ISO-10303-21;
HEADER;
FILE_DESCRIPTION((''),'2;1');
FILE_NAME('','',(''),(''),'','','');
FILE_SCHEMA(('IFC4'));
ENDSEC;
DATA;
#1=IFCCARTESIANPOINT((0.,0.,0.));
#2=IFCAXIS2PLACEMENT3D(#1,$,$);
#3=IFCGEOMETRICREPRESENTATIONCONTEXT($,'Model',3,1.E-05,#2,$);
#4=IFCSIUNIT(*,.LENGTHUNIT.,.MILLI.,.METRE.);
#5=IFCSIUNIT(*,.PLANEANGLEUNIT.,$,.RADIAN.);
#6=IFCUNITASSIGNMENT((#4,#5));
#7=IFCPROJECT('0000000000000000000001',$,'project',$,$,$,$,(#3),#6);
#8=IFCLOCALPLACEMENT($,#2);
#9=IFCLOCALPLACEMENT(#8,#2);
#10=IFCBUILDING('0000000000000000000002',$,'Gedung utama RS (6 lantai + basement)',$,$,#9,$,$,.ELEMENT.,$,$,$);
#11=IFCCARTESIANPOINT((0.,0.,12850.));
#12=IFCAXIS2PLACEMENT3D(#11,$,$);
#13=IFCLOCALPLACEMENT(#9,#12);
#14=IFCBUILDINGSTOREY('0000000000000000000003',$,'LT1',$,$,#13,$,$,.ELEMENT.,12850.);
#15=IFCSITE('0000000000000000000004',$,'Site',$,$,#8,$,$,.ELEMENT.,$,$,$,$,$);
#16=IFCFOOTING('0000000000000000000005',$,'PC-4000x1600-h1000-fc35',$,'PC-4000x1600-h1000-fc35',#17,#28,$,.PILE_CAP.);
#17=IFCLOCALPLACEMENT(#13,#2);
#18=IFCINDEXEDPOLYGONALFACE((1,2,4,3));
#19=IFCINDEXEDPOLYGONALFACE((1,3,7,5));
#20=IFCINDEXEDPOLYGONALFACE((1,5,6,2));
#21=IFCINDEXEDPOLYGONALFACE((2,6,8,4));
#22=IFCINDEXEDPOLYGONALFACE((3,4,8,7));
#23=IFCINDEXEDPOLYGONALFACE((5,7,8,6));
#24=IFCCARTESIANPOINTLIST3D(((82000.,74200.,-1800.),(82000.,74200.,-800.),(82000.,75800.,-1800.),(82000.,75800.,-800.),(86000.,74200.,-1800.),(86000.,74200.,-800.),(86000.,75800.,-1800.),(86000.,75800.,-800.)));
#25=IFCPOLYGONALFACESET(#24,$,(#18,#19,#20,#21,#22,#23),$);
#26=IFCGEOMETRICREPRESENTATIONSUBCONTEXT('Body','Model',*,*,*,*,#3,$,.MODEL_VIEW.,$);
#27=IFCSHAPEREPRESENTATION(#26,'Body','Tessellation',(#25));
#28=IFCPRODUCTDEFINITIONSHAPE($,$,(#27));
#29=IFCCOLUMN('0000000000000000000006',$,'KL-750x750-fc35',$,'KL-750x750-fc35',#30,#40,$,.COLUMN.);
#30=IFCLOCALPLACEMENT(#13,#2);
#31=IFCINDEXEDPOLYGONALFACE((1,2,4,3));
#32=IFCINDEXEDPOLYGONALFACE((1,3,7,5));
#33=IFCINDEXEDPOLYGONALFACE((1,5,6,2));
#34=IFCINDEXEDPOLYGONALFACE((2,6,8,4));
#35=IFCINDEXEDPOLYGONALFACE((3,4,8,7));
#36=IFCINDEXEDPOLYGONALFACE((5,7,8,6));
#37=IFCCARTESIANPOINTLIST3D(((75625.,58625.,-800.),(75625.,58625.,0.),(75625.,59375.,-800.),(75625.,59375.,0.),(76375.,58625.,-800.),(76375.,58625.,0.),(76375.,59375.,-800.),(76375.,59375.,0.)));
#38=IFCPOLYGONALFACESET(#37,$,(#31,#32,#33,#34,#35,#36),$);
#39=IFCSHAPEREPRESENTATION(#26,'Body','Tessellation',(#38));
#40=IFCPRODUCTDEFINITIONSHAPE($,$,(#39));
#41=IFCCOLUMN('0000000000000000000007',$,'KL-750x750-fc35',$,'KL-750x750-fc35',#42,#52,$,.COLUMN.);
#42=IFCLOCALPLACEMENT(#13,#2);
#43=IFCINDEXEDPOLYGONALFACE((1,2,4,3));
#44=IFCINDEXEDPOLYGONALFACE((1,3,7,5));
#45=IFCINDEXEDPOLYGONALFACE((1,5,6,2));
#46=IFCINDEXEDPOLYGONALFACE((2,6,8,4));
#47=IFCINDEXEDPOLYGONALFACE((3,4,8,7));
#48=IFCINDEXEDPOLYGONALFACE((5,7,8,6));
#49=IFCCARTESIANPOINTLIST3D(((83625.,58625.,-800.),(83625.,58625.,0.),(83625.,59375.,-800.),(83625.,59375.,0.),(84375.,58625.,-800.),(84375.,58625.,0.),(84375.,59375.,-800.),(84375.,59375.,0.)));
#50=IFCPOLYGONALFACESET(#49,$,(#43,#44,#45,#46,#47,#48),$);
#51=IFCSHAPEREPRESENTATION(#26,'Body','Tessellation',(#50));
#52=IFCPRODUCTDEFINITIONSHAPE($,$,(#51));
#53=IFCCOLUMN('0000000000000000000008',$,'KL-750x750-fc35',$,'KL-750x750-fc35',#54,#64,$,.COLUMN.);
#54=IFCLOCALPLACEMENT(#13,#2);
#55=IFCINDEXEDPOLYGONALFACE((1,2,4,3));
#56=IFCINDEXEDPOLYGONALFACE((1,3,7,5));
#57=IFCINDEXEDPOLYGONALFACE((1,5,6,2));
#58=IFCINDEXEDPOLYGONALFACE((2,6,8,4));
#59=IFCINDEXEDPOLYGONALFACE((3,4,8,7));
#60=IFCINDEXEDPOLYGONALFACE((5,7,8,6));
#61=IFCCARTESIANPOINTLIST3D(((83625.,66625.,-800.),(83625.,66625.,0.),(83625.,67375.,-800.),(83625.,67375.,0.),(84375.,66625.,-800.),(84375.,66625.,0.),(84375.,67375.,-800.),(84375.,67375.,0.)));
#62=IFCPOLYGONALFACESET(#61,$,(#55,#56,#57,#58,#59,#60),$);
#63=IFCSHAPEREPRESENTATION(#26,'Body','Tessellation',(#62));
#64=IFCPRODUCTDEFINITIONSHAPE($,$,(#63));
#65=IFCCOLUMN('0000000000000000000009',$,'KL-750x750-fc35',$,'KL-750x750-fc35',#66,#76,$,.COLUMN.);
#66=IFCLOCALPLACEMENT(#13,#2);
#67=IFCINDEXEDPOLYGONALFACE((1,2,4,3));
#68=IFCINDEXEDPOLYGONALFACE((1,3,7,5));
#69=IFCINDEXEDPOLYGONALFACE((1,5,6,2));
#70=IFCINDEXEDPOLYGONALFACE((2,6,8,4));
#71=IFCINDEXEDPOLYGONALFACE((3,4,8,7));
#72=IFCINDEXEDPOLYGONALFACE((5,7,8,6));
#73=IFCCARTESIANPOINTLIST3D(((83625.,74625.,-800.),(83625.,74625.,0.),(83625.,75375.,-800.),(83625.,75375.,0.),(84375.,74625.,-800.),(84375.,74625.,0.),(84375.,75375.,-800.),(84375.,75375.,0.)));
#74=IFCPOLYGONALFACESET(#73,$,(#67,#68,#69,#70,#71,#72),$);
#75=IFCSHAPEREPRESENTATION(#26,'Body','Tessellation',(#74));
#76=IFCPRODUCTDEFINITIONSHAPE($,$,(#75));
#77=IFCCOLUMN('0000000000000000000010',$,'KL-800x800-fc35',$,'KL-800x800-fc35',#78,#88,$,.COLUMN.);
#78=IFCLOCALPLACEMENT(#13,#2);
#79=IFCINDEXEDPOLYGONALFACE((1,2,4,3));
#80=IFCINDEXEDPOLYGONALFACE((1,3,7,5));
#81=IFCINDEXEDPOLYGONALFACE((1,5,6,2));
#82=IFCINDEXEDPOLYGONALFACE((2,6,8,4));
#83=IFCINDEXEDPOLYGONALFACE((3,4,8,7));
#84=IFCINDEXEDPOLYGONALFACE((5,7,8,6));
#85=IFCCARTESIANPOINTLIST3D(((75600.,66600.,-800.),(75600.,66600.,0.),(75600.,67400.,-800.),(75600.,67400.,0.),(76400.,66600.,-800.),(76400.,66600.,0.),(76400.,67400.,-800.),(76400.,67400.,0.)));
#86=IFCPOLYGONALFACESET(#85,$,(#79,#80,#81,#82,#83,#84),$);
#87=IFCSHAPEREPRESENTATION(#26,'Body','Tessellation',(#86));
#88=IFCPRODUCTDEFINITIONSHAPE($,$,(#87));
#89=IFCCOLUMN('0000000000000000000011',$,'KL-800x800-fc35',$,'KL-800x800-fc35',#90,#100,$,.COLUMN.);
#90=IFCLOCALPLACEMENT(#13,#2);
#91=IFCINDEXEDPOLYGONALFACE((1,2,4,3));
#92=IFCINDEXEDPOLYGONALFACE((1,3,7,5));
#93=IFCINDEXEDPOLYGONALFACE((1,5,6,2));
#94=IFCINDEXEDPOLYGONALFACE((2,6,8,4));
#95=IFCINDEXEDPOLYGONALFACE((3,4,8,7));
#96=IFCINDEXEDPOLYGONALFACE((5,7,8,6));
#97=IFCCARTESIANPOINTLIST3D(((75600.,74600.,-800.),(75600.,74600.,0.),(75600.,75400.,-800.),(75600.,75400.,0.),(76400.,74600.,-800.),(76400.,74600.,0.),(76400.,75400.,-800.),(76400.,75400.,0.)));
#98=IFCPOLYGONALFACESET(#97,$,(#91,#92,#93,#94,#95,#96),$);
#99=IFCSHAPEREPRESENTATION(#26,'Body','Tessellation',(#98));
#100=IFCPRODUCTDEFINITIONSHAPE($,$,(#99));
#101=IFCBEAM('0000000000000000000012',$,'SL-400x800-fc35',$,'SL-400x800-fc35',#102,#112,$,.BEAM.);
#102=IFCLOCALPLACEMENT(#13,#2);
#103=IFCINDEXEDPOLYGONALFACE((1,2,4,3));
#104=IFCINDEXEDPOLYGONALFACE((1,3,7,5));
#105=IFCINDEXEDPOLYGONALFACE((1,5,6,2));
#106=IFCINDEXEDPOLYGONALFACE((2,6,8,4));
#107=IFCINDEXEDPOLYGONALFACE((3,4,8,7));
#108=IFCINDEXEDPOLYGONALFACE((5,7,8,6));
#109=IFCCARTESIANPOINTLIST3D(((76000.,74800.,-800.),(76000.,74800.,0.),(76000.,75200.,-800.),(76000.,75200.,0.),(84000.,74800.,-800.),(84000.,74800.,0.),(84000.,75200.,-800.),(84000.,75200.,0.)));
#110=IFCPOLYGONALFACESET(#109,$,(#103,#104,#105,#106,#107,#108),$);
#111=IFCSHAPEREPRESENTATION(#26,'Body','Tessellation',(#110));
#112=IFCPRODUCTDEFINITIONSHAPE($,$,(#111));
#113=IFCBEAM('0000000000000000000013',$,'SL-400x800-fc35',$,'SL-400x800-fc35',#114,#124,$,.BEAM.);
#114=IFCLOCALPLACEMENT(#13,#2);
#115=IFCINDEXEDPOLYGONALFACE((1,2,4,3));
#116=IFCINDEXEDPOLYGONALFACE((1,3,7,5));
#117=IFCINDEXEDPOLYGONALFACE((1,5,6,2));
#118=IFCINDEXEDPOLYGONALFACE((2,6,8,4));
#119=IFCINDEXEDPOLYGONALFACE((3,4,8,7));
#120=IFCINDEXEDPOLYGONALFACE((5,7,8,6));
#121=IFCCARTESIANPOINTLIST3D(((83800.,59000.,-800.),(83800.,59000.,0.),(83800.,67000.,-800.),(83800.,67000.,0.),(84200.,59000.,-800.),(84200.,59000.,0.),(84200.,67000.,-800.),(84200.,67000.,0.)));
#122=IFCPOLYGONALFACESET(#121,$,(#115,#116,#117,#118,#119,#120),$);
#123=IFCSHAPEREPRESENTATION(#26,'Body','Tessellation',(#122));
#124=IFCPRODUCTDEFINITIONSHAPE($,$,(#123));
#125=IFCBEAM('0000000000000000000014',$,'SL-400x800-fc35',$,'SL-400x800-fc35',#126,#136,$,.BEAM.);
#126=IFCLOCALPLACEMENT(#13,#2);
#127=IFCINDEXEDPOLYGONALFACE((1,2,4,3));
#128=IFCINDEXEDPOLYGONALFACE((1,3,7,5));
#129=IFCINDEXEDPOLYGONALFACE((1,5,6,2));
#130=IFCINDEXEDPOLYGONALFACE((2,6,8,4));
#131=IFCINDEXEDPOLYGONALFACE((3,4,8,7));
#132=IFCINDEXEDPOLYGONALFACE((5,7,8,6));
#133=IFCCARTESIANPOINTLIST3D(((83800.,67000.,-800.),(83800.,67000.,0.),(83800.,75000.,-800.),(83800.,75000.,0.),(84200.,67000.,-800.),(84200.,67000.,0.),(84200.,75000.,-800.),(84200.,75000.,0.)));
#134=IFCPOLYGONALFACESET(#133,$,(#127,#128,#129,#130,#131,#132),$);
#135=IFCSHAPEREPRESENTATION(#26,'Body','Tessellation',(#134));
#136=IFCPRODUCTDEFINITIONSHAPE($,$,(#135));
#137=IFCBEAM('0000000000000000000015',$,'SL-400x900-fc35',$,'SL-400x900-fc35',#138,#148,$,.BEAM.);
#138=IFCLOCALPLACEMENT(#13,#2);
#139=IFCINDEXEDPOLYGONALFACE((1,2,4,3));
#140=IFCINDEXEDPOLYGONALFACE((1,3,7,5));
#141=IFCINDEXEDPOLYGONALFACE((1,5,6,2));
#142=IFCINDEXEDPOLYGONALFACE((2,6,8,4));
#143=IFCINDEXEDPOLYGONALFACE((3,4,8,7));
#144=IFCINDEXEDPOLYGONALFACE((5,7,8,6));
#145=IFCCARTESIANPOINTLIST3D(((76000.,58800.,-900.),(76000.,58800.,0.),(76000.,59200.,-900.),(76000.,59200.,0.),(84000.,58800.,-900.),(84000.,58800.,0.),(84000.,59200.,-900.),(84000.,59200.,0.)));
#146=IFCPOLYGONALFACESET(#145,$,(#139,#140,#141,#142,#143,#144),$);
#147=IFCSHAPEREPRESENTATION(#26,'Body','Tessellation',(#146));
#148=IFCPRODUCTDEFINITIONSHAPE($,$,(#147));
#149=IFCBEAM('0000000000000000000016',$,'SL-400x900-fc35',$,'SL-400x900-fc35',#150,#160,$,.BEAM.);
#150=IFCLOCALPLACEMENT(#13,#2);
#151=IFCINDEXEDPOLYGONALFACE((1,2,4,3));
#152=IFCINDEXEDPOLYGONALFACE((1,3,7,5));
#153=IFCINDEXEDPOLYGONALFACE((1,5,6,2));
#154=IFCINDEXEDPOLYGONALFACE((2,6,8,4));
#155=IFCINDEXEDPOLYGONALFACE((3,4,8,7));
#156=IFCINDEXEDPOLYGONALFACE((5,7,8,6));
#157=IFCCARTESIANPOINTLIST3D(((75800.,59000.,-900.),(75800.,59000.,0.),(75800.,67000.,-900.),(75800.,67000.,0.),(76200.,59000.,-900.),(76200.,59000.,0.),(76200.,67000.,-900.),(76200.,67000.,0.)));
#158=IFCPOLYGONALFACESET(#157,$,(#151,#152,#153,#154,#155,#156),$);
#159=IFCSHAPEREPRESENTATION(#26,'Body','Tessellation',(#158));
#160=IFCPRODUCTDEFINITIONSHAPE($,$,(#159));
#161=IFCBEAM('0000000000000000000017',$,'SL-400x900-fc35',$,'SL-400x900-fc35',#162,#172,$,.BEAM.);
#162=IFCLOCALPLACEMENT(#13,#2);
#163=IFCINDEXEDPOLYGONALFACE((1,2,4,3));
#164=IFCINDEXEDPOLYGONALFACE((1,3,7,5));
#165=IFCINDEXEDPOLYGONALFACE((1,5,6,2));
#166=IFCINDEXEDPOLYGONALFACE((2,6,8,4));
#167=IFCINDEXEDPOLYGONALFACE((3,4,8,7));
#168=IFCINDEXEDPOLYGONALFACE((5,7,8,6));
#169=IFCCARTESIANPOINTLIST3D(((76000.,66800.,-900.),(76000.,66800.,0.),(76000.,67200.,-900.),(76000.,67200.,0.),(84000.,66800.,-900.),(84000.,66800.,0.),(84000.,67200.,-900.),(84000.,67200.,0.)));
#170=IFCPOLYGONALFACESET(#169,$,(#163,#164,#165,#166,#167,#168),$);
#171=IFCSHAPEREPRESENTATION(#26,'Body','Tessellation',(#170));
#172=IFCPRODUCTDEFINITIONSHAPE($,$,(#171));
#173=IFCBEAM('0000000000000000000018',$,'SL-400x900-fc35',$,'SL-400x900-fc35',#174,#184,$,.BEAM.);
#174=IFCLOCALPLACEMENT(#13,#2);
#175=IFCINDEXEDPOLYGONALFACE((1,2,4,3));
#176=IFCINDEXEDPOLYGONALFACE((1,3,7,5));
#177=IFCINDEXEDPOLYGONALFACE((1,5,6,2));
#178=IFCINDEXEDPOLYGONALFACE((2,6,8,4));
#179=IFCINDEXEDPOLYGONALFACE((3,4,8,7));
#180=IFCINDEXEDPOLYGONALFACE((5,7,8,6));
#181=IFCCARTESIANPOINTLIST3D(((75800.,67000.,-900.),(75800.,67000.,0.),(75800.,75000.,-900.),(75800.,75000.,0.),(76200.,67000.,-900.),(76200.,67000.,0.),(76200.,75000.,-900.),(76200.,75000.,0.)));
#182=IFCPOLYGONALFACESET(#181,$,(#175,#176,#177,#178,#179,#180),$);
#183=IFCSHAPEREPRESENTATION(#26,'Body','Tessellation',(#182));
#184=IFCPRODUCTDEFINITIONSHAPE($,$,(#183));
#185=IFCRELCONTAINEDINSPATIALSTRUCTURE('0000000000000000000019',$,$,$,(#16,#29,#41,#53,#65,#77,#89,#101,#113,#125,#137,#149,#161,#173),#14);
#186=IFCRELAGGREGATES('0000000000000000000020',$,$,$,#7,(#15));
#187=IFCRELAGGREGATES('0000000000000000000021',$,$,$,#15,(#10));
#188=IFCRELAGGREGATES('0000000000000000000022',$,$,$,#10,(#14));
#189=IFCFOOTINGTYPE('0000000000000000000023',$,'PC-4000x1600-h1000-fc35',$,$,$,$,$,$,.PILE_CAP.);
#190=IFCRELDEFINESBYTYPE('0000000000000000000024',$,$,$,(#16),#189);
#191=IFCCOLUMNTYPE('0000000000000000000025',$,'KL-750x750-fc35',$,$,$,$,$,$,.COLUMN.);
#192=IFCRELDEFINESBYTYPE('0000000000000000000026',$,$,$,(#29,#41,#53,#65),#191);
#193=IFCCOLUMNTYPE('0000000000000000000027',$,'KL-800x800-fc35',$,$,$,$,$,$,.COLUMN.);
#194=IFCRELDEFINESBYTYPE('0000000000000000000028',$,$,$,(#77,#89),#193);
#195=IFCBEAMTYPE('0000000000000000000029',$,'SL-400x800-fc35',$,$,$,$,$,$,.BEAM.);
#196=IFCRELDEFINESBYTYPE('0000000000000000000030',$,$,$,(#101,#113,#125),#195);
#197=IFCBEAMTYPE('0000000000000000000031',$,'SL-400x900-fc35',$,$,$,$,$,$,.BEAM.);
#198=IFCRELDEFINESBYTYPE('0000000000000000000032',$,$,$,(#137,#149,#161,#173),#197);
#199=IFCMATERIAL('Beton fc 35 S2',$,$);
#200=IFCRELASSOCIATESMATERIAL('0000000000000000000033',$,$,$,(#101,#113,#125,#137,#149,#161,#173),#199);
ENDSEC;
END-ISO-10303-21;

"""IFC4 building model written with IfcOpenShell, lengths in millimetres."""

from ifc_helpers import new_model, si_unit, frame, origin, origin_2d, place, context, subcontext, project, spatial, rectangle, extrude, material, material_profile, profile_set, profile_usage, type_object, element, save


model = new_model("IFC4")

# Units and contexts
model_context = context("Model", 3, precision=1e-05, world=origin())
body_context = subcontext(model_context, "Body", "Model", "MODEL_VIEW")
ifc_project = project(units=[si_unit("LENGTHUNIT", "METRE", prefix="MILLI"), si_unit("PLANEANGLEUNIT", "RADIAN")], contexts=[model_context])

# Site, building, storey
site_placement = place(None, origin())
site = spatial("IfcSite", under=ifc_project, at=site_placement, Name="Site", CompositionType="ELEMENT")
building_placement = place(site_placement, origin())
building = spatial("IfcBuilding", under=site, at=building_placement, Name="Gedung utama RS (6 lantai + basement)", CompositionType="ELEMENT")
storey_placement = place(building_placement, frame((0.0, 0.0, 12850.0)))
storey = spatial("IfcBuildingStorey", under=building, at=storey_placement, Name="LT1", CompositionType="ELEMENT", Elevation=12850.0)

# Footing
ifc_material_profile_1 = material_profile(None, rectangle(XDim=4000.0, YDim=1600.0, at=origin_2d()), Name="PC-4000x1600-h1000-fc35")
ifc_profile_set_1 = profile_set([ifc_material_profile_1], Name="PC-4000x1600-h1000-fc35")
ifc_profile_usage_1 = profile_usage(ifc_profile_set_1, cardinal=5)
footing_type = type_object("IfcFootingType", Name="PC-4000x1600-h1000-fc35", PredefinedType="PILE_CAP")
footing_placement = place(storey_placement, frame((84000.0, 75000.0, -1800.0), z_axis=(0.0, 0.0, 1.0), x_axis=(1.0, 0.0, 0.0)))
element("IfcFooting", 1, at=footing_placement, inside=storey, type_object=footing_type, material=ifc_profile_usage_1, Name="PC-4000x1600-h1000-fc35", ObjectType="PC-4000x1600-h1000-fc35", PredefinedType="PILE_CAP", context=body_context, shape_type="SweptSolid", body=[
    extrude(rectangle(XDim=4000.0, YDim=1600.0, at=origin_2d()), origin(), (0.0, 0.0, 1.0), 1000.0),
])

# Columns
ifc_material_profile_2 = material_profile(None, rectangle(XDim=750.0, YDim=750.0, at=origin_2d()), Name="KL-750x750-fc35")
ifc_profile_set_2 = profile_set([ifc_material_profile_2], Name="KL-750x750-fc35")
ifc_profile_usage_2 = profile_usage(ifc_profile_set_2, cardinal=5)
column_type_1 = type_object("IfcColumnType", Name="KL-750x750-fc35", PredefinedType="COLUMN")
for number, where, z_axis, x_axis, name in (
    (2, (76000.0, 59000.0, -800.0), (0.0, 0.0, 1.0), (1.0, 0.0, 0.0), "KL-750x750-fc35"),
    (3, (84000.0, 59000.0, -800.0), (0.0, 0.0, 1.0), (1.0, 0.0, 0.0), "KL-750x750-fc35"),
    (4, (84000.0, 67000.0, -800.0), (0.0, 0.0, 1.0), (1.0, 0.0, 0.0), "KL-750x750-fc35"),
    (5, (84000.0, 75000.0, -800.0), (0.0, 0.0, 1.0), (1.0, 0.0, 0.0), "KL-750x750-fc35"),
):
    element("IfcColumn", number, at=place(storey_placement, frame(where, z_axis=z_axis, x_axis=x_axis)), inside=storey, type_object=column_type_1, material=ifc_profile_usage_2, Name=name, ObjectType="KL-750x750-fc35", PredefinedType="COLUMN", context=body_context, shape_type="SweptSolid", body=[
        extrude(rectangle(XDim=750.0, YDim=750.0, at=origin_2d()), origin(), (0.0, 0.0, 1.0), 800.0),
    ])
ifc_material_profile_3 = material_profile(None, rectangle(XDim=800.0, YDim=800.0, at=origin_2d()), Name="KL-800x800-fc35")
ifc_profile_set_3 = profile_set([ifc_material_profile_3], Name="KL-800x800-fc35")
ifc_profile_usage_3 = profile_usage(ifc_profile_set_3, cardinal=5)
column_type_2 = type_object("IfcColumnType", Name="KL-800x800-fc35", PredefinedType="COLUMN")
for number, where, z_axis, x_axis, name in (
    (6, (76000.0, 67000.0, -800.0), (0.0, 0.0, 1.0), (1.0, 0.0, 0.0), "KL-800x800-fc35"),
    (7, (76000.0, 75000.0, -800.0), (0.0, 0.0, 1.0), (1.0, 0.0, 0.0), "KL-800x800-fc35"),
):
    element("IfcColumn", number, at=place(storey_placement, frame(where, z_axis=z_axis, x_axis=x_axis)), inside=storey, type_object=column_type_2, material=ifc_profile_usage_3, Name=name, ObjectType="KL-800x800-fc35", PredefinedType="COLUMN", context=body_context, shape_type="SweptSolid", body=[
        extrude(rectangle(XDim=800.0, YDim=800.0, at=origin_2d()), origin(), (0.0, 0.0, 1.0), 800.0),
    ])

# Beams
ifc_material_1 = material(Name="Beton fc 35 S2")
ifc_material_profile_4 = material_profile(ifc_material_1, rectangle(XDim=400.0, YDim=800.0, at=origin_2d()), Name="SL-400x800-fc35")
ifc_profile_set_4 = profile_set([ifc_material_profile_4], Name="SL-400x800-fc35")
ifc_profile_usage_4 = profile_usage(ifc_profile_set_4, cardinal=8)
beam_type_1 = type_object("IfcBeamType", Name="SL-400x800-fc35", PredefinedType="BEAM")
beam_1_placement = place(storey_placement, frame((76000.0, 75000.0, -400.0)))
element("IfcBeam", 8, at=beam_1_placement, inside=storey, type_object=beam_type_1, material=ifc_profile_usage_4, Name="SL-400x800-fc35", ObjectType="SL-400x800-fc35", PredefinedType="BEAM", context=body_context, shape_type="SweptSolid", body=[
    extrude(rectangle(XDim=400.0, YDim=800.0, at=origin_2d()), frame((0.0, 0.0, 0.0), z_axis=(1.0, 0.0, 0.0), x_axis=(0.0, 1.0, 0.0)), (0.0, 0.0, 1.0), 8000.0),
])
for number, where, name in (
    (9, (84000.0, 59000.0, -400.0), "SL-400x800-fc35"),
    (10, (84000.0, 67000.0, -400.0), "SL-400x800-fc35"),
):
    element("IfcBeam", number, at=place(storey_placement, frame(where)), inside=storey, type_object=beam_type_1, material=ifc_profile_usage_4, Name=name, ObjectType="SL-400x800-fc35", PredefinedType="BEAM", context=body_context, shape_type="SweptSolid", body=[
        extrude(rectangle(XDim=400.0, YDim=800.0, at=origin_2d()), frame((0.0, 0.0, 0.0), z_axis=(0.0, 1.0, 0.0), x_axis=(-1.0, 0.0, 0.0)), (0.0, 0.0, 1.0), 8000.0),
    ])
ifc_material_profile_5 = material_profile(ifc_material_1, rectangle(XDim=400.0, YDim=900.0, at=origin_2d()), Name="SL-400x900-fc35")
ifc_profile_set_5 = profile_set([ifc_material_profile_5], Name="SL-400x900-fc35")
ifc_profile_usage_5 = profile_usage(ifc_profile_set_5, cardinal=8)
beam_type_2 = type_object("IfcBeamType", Name="SL-400x900-fc35", PredefinedType="BEAM")
beam_2_placement = place(storey_placement, frame((76000.0, 59000.0, -450.0)))
element("IfcBeam", 11, at=beam_2_placement, inside=storey, type_object=beam_type_2, material=ifc_profile_usage_5, Name="SL-400x900-fc35", ObjectType="SL-400x900-fc35", PredefinedType="BEAM", context=body_context, shape_type="SweptSolid", body=[
    extrude(rectangle(XDim=400.0, YDim=900.0, at=origin_2d()), frame((0.0, 0.0, 0.0), z_axis=(1.0, 0.0, 0.0), x_axis=(0.0, 1.0, 0.0)), (0.0, 0.0, 1.0), 8000.0),
])
beam_3_placement = place(storey_placement, frame((76000.0, 59000.0, -450.0)))
element("IfcBeam", 12, at=beam_3_placement, inside=storey, type_object=beam_type_2, material=ifc_profile_usage_5, Name="SL-400x900-fc35", ObjectType="SL-400x900-fc35", PredefinedType="BEAM", context=body_context, shape_type="SweptSolid", body=[
    extrude(rectangle(XDim=400.0, YDim=900.0, at=origin_2d()), frame((0.0, 0.0, 0.0), z_axis=(0.0, 1.0, 0.0), x_axis=(-1.0, 0.0, 0.0)), (0.0, 0.0, 1.0), 8000.0),
])
beam_4_placement = place(storey_placement, frame((76000.0, 67000.0, -450.0)))
element("IfcBeam", 13, at=beam_4_placement, inside=storey, type_object=beam_type_2, material=ifc_profile_usage_5, Name="SL-400x900-fc35", ObjectType="SL-400x900-fc35", PredefinedType="BEAM", context=body_context, shape_type="SweptSolid", body=[
    extrude(rectangle(XDim=400.0, YDim=900.0, at=origin_2d()), frame((0.0, 0.0, 0.0), z_axis=(1.0, 0.0, 0.0), x_axis=(0.0, 1.0, 0.0)), (0.0, 0.0, 1.0), 8000.0),
])
beam_5_placement = place(storey_placement, frame((76000.0, 67000.0, -450.0)))
element("IfcBeam", 14, at=beam_5_placement, inside=storey, type_object=beam_type_2, material=ifc_profile_usage_5, Name="SL-400x900-fc35", ObjectType="SL-400x900-fc35", PredefinedType="BEAM", context=body_context, shape_type="SweptSolid", body=[
    extrude(rectangle(XDim=400.0, YDim=900.0, at=origin_2d()), frame((0.0, 0.0, 0.0), z_axis=(0.0, 1.0, 0.0), x_axis=(-1.0, 0.0, 0.0)), (0.0, 0.0, 1.0), 8000.0),
])

save(model, "model.ifc")
